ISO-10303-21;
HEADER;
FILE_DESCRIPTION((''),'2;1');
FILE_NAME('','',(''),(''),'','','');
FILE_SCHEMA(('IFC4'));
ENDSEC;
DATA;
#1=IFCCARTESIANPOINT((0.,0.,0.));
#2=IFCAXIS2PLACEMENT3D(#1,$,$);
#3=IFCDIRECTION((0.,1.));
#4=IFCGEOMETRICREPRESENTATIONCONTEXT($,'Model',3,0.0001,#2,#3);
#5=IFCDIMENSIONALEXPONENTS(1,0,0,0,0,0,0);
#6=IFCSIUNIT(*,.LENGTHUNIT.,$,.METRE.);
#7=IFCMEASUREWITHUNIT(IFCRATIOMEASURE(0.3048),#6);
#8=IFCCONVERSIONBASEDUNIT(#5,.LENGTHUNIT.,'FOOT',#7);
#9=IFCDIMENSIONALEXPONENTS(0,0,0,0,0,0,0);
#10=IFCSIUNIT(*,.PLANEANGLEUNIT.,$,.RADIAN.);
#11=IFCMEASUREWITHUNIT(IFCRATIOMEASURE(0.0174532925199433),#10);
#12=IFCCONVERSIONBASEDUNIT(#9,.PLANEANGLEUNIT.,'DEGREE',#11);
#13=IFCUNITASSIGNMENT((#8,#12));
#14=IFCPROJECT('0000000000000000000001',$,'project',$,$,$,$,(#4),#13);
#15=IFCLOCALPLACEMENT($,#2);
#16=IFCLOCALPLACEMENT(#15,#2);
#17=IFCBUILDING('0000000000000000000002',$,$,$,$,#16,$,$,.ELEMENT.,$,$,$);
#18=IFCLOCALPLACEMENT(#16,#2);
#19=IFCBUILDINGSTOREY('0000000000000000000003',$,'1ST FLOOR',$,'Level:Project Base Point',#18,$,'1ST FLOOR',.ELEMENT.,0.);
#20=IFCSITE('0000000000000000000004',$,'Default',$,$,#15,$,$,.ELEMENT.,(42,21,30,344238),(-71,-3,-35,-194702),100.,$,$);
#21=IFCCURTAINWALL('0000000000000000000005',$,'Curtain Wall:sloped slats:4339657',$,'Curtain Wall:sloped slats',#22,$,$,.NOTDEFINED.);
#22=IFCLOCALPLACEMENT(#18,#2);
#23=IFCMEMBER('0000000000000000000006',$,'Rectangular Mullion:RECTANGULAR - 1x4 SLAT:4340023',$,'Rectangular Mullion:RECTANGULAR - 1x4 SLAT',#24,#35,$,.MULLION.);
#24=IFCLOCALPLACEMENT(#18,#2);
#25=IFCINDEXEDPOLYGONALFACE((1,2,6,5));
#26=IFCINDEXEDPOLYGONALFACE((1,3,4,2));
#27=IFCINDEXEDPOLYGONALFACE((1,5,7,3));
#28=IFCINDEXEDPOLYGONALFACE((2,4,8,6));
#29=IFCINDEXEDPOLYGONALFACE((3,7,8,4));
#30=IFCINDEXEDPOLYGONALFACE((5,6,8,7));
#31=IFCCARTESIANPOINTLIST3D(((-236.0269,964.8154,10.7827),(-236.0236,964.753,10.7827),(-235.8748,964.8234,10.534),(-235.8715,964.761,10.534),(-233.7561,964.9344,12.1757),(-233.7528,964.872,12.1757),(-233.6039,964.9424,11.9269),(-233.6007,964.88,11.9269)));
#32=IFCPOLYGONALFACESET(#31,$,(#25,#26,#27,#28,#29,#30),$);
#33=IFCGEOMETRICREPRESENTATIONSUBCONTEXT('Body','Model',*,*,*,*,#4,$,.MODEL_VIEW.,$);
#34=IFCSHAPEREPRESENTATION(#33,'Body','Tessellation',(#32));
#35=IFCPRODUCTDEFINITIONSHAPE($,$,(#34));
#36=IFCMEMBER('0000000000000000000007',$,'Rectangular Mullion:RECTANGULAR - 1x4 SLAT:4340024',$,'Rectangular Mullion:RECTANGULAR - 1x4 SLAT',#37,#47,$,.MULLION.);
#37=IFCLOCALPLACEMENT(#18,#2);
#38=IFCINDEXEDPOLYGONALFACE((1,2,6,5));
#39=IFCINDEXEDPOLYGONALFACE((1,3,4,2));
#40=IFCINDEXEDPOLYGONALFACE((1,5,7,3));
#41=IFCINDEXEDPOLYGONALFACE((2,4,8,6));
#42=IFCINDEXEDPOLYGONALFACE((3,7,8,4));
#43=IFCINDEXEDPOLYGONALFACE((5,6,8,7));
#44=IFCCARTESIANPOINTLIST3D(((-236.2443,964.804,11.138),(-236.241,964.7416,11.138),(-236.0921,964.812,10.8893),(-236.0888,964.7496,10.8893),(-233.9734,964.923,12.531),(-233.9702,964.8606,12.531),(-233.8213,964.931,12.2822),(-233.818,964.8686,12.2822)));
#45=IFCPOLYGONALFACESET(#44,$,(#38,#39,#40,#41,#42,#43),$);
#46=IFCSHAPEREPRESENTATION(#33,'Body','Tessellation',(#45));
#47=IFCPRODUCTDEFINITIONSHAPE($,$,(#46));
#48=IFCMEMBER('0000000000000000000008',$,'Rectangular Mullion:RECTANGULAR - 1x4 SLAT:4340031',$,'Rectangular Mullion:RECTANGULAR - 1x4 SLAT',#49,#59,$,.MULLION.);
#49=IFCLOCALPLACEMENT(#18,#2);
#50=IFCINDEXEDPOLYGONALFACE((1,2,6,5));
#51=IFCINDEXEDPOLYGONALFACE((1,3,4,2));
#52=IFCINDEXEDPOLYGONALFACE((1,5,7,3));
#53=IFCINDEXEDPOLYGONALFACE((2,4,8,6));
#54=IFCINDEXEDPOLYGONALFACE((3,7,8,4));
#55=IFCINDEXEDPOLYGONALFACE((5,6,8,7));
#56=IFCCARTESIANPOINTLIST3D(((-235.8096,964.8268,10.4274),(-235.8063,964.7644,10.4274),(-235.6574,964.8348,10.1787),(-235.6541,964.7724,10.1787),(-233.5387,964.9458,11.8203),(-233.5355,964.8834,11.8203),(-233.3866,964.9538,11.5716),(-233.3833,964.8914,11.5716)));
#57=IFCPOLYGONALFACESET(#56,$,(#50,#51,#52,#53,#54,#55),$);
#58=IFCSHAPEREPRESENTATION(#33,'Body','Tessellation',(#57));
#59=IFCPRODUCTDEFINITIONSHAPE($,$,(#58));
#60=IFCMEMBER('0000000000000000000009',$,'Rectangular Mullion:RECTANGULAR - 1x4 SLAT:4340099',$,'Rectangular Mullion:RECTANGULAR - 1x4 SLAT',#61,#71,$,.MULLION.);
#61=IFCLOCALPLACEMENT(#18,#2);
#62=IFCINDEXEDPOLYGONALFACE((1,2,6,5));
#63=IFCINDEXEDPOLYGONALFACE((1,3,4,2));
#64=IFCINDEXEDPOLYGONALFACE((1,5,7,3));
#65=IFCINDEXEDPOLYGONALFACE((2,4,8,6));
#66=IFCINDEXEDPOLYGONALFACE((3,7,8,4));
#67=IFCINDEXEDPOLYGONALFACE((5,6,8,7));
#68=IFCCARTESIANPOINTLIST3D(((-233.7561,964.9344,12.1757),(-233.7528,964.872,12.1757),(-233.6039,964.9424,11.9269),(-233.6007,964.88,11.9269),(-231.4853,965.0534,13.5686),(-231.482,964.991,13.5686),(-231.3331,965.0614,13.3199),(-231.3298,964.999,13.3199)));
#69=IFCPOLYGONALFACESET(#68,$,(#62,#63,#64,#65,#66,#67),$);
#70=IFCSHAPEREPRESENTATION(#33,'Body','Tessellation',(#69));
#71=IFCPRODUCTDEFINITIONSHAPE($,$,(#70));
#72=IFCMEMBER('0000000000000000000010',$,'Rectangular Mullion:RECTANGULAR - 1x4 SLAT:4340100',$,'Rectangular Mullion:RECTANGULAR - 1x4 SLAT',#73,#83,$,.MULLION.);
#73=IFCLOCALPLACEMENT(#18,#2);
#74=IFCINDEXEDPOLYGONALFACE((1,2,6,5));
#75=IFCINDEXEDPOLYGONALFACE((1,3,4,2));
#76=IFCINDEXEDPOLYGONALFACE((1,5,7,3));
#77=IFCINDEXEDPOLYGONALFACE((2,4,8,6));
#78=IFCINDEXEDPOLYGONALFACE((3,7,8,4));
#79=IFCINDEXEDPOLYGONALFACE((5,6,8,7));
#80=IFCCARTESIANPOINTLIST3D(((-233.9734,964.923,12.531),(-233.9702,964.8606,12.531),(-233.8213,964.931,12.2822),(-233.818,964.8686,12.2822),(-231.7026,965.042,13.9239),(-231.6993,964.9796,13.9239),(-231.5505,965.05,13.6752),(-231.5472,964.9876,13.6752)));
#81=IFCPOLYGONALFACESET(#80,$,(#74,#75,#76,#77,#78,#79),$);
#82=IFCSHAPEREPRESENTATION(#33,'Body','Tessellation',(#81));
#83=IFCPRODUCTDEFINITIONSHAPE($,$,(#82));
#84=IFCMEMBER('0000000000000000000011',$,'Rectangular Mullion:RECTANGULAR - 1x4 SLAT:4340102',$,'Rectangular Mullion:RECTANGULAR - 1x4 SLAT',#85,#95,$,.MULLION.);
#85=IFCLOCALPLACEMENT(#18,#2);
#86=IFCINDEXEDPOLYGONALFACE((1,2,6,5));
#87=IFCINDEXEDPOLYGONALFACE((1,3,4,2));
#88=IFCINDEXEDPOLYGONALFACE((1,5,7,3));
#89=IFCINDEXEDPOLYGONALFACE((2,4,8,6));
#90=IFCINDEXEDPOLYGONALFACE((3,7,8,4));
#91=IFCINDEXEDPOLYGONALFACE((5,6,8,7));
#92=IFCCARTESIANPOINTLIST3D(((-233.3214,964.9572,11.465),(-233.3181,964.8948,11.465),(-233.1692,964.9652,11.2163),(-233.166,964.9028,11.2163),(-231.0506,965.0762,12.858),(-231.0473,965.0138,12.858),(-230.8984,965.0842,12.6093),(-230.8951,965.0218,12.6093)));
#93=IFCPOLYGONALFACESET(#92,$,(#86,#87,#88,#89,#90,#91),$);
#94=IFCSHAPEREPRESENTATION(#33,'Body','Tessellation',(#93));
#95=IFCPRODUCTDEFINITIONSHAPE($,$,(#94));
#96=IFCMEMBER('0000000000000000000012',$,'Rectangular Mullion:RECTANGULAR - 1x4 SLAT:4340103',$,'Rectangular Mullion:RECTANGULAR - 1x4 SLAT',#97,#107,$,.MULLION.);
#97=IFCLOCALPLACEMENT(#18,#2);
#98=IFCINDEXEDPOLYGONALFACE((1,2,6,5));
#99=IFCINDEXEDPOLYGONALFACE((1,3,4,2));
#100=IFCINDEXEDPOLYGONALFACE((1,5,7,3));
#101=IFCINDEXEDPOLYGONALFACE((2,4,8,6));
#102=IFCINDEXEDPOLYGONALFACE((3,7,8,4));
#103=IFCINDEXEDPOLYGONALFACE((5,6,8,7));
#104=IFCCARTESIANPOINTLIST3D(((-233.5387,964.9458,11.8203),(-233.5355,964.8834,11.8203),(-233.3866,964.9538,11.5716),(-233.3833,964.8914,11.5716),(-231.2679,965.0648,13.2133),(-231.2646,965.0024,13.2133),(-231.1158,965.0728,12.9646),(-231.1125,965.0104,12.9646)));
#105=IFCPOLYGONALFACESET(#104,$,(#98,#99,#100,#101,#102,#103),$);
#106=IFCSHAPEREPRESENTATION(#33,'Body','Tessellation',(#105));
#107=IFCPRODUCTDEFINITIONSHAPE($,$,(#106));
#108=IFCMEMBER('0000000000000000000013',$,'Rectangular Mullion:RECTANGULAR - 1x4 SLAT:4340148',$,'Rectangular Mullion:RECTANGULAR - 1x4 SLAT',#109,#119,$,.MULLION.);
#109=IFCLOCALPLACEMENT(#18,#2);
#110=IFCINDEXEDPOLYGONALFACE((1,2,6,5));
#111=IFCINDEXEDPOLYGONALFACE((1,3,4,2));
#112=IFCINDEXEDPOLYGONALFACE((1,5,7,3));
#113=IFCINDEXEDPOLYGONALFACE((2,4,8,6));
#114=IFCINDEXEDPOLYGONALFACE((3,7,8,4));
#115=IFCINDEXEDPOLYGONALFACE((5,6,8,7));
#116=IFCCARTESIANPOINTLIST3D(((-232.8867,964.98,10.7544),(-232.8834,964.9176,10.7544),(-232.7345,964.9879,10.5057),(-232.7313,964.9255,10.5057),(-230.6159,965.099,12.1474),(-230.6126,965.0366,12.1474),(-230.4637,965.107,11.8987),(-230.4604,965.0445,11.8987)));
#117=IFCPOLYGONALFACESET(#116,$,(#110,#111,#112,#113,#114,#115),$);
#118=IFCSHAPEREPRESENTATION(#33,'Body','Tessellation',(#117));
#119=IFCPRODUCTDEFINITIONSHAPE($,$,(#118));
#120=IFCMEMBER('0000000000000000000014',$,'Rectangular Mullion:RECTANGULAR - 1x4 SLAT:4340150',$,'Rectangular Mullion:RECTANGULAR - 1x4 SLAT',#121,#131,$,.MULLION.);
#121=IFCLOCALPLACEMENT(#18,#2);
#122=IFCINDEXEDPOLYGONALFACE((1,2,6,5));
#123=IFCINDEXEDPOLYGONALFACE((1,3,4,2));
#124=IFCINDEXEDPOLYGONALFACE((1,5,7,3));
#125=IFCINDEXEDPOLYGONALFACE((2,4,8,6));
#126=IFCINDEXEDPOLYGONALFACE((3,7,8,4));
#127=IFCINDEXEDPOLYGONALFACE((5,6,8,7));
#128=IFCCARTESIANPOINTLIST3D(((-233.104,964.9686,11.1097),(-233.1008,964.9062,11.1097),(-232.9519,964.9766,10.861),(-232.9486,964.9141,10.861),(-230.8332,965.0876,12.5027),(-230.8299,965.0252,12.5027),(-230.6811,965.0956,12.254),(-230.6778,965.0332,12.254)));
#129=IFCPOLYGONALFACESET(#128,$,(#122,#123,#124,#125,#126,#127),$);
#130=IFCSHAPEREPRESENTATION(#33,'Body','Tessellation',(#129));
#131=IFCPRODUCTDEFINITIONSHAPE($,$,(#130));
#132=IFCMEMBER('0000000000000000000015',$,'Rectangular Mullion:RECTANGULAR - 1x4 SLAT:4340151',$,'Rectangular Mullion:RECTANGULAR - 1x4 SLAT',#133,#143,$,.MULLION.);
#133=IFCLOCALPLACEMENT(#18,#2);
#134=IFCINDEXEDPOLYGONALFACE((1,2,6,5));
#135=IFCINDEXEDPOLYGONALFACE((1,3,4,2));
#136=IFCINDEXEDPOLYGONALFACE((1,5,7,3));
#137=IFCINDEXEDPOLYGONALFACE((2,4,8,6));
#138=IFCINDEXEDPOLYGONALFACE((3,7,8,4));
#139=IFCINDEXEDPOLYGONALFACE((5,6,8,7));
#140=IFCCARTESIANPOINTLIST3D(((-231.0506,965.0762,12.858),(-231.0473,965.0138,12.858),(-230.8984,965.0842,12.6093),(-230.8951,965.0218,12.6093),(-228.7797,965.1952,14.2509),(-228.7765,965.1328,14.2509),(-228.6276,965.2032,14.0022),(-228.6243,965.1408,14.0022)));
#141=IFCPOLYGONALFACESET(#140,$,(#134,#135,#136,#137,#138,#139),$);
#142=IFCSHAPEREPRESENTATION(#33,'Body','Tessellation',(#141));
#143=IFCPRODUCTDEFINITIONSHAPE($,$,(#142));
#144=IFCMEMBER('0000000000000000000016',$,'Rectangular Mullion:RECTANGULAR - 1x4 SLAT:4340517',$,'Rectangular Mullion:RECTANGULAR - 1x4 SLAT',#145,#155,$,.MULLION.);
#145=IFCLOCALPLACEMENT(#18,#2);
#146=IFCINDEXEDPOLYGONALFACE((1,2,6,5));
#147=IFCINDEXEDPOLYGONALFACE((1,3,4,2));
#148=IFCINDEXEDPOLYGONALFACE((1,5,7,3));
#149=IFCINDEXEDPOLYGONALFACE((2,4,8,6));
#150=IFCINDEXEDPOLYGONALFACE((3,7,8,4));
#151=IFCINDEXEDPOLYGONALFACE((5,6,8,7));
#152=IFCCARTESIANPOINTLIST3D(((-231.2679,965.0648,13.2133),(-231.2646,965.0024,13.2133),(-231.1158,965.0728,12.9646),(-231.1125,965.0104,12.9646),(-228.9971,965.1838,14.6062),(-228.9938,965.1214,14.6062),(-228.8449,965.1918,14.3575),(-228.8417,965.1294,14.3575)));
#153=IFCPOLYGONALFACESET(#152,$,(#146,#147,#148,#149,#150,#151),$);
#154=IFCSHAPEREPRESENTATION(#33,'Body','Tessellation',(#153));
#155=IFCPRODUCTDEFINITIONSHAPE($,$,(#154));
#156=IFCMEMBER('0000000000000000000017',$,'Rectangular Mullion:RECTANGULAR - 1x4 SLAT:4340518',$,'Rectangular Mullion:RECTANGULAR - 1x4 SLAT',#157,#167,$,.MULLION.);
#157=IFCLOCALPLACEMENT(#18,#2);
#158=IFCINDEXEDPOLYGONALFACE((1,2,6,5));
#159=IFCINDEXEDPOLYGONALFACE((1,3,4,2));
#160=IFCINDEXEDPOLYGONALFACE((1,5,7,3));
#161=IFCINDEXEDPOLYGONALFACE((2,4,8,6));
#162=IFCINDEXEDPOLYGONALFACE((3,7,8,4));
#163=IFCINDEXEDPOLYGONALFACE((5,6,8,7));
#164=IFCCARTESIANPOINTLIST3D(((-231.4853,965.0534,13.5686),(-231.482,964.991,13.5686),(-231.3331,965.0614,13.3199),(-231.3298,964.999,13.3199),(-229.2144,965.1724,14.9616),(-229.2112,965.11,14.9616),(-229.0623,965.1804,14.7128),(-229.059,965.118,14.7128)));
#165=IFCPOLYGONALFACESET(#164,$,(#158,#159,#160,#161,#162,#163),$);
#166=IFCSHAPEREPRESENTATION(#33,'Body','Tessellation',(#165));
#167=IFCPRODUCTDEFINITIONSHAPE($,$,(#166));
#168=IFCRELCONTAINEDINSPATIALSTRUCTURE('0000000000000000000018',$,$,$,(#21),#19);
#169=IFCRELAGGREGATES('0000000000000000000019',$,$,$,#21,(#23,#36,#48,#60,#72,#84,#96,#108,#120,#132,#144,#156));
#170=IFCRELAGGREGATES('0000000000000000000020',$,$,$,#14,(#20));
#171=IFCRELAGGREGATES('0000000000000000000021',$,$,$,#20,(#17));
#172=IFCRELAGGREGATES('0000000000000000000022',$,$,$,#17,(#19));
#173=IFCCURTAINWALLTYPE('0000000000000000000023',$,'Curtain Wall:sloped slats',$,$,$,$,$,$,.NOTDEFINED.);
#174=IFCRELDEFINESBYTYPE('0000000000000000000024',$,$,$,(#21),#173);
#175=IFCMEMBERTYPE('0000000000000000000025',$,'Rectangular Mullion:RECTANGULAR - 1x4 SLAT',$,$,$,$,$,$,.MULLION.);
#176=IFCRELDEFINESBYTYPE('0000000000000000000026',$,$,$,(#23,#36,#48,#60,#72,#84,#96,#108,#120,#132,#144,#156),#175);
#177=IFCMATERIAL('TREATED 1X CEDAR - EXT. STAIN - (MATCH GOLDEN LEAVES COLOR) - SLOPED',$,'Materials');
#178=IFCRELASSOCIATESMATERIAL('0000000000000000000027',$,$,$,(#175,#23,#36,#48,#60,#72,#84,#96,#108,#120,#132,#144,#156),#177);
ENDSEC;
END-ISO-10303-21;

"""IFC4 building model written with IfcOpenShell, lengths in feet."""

from ifc_helpers import new_model, entity, si_unit, converted_unit, direction, frame, frame_2d, origin, place, context, subcontext, project, spatial, rectangle, extrude, source, transform, mapped, material, material_profile, profile_set, profile_usage, type_object, type_shapes, element, aggregate, save


model = new_model("IFC4")

# Units and contexts
model_context = context("Model", 3, precision=0.0001, world=origin(), true_north=direction((0.0, 1.0)))
body_context = subcontext(model_context, "Body", "Model", "MODEL_VIEW")
ifc_project = project(units=[converted_unit("LENGTHUNIT", "FOOT", entity("IfcRatioMeasure", 0.3048), si_unit("LENGTHUNIT", "METRE"), dimensions=[1, 0, 0, 0, 0, 0, 0]), converted_unit("PLANEANGLEUNIT", "DEGREE", entity("IfcRatioMeasure", 0.0174532925199433), si_unit("PLANEANGLEUNIT", "RADIAN"), dimensions=[0, 0, 0, 0, 0, 0, 0])], contexts=[model_context])

# Site, building, storey
site_placement = place(None, origin())
site = spatial("IfcSite", under=ifc_project, at=site_placement, Name="Default", CompositionType="ELEMENT", RefLatitude=(42, 21, 30, 344238), RefLongitude=(-71, -3, -35, -194702), RefElevation=100.0)
building_placement = place(site_placement, origin())
building = spatial("IfcBuilding", under=site, at=building_placement, CompositionType="ELEMENT")
storey_placement = place(building_placement, origin())
storey = spatial("IfcBuildingStorey", under=building, at=storey_placement, Name="1ST FLOOR", ObjectType="Level:Project Base Point", LongName="1ST FLOOR", CompositionType="ELEMENT", Elevation=0.0)

# Curtain wall, members
curtain_wall_type_1 = type_object("IfcCurtainWallType", Name="Curtain Wall:sloped slats", PredefinedType="NOTDEFINED")
curtain_wall_1_placement = place(storey_placement, origin())
curtain_wall_1 = element("IfcCurtainWall", 1, at=curtain_wall_1_placement, inside=storey, type_object=curtain_wall_type_1, Name="Curtain Wall:sloped slats:4339657", ObjectType="Curtain Wall:sloped slats", PredefinedType="NOTDEFINED")
ifc_material_1 = material(Name="TREATED 1X CEDAR - EXT. STAIN - (MATCH GOLDEN LEAVES COLOR) - SLOPED", Category="Materials")
ifc_material_profile_1 = material_profile(ifc_material_1, rectangle(XDim=0.0625, YDim=0.2917, at=frame_2d((0.0, 0.0), x_axis=(1.0, 0.0))), Name="RECTANGULAR - 1x4 SLAT")
ifc_profile_set_1 = profile_set([ifc_material_profile_1], Name="RECTANGULAR - 1x4 SLAT")
ifc_profile_usage_1 = profile_usage(ifc_profile_set_1)
member_type_1 = type_object("IfcMemberType", Name="Rectangular Mullion:RECTANGULAR - 1x4 SLAT", PredefinedType="MULLION", material=ifc_profile_set_1)
shared_shape_1 = source(origin(), body_context, "Body", "SweptSolid", [
    extrude(rectangle(XDim=0.0625, YDim=0.2917, at=frame_2d((0.0, 0.0), x_axis=(1.0, 0.0))), frame((0.0, 0.0, -2.6667), z_axis=(0.0, 0.0, 1.0), x_axis=(0.0, -1.0, 0.0)), (0.0, 0.0, 1.0), 2.6667),
])
type_shapes(member_type_1, [shared_shape_1])
member_1_placement = place(storey_placement, frame((-235.9492, 964.7882, 10.6583), z_axis=(-0.851559, -0.044628, -0.522356), x_axis=(-0.52164, -0.027338, 0.852727)))
member_1 = element("IfcMember", 2, at=member_1_placement, type_object=member_type_1, material=ifc_profile_usage_1, Name="Rectangular Mullion:RECTANGULAR - 1x4 SLAT:4340023", ObjectType="Rectangular Mullion:RECTANGULAR - 1x4 SLAT", PredefinedType="MULLION", context=body_context, shape_type="MappedRepresentation", body=[
    mapped(shared_shape_1, transform((0.0, 0.0, 0.0), scale=1.0)),
])
ifc_profile_usage_2 = profile_usage(ifc_profile_set_1)
member_2_placement = place(storey_placement, frame((-236.1666, 964.7768, 11.0136), z_axis=(-0.851559, -0.044628, -0.522356), x_axis=(-0.52164, -0.027338, 0.852727)))
member_2 = element("IfcMember", 3, at=member_2_placement, type_object=member_type_1, material=ifc_profile_usage_2, Name="Rectangular Mullion:RECTANGULAR - 1x4 SLAT:4340024", ObjectType="Rectangular Mullion:RECTANGULAR - 1x4 SLAT", PredefinedType="MULLION", context=body_context, shape_type="MappedRepresentation", body=[
    mapped(shared_shape_1, transform((0.0, 0.0, 0.0), scale=1.0)),
])
ifc_profile_usage_3 = profile_usage(ifc_profile_set_1)
member_3_placement = place(storey_placement, frame((-235.7319, 964.7996, 10.303), z_axis=(-0.851559, -0.044628, -0.522356), x_axis=(-0.52164, -0.027338, 0.852727)))
member_3 = element("IfcMember", 4, at=member_3_placement, type_object=member_type_1, material=ifc_profile_usage_3, Name="Rectangular Mullion:RECTANGULAR - 1x4 SLAT:4340031", ObjectType="Rectangular Mullion:RECTANGULAR - 1x4 SLAT", PredefinedType="MULLION", context=body_context, shape_type="MappedRepresentation", body=[
    mapped(shared_shape_1, transform((0.0, 0.0, 0.0), scale=1.0)),
])
ifc_profile_usage_4 = profile_usage(ifc_profile_set_1)
member_4_placement = place(storey_placement, frame((-233.6784, 964.9072, 12.0513), z_axis=(-0.851559, -0.044628, -0.522356), x_axis=(-0.52164, -0.027338, 0.852727)))
member_4 = element("IfcMember", 5, at=member_4_placement, type_object=member_type_1, material=ifc_profile_usage_4, Name="Rectangular Mullion:RECTANGULAR - 1x4 SLAT:4340099", ObjectType="Rectangular Mullion:RECTANGULAR - 1x4 SLAT", PredefinedType="MULLION", context=body_context, shape_type="MappedRepresentation", body=[
    mapped(shared_shape_1, transform((0.0, 0.0, 0.0), scale=1.0)),
])
ifc_profile_usage_5 = profile_usage(ifc_profile_set_1)
member_5_placement = place(storey_placement, frame((-233.8957, 964.8958, 12.4066), z_axis=(-0.851559, -0.044628, -0.522356), x_axis=(-0.52164, -0.027338, 0.852727)))
member_5 = element("IfcMember", 6, at=member_5_placement, type_object=member_type_1, material=ifc_profile_usage_5, Name="Rectangular Mullion:RECTANGULAR - 1x4 SLAT:4340100", ObjectType="Rectangular Mullion:RECTANGULAR - 1x4 SLAT", PredefinedType="MULLION", context=body_context, shape_type="MappedRepresentation", body=[
    mapped(shared_shape_1, transform((0.0, 0.0, 0.0), scale=1.0)),
])
ifc_profile_usage_6 = profile_usage(ifc_profile_set_1)
member_6_placement = place(storey_placement, frame((-233.2437, 964.93, 11.3407), z_axis=(-0.851559, -0.044628, -0.522356), x_axis=(-0.52164, -0.027338, 0.852727)))
member_6 = element("IfcMember", 7, at=member_6_placement, type_object=member_type_1, material=ifc_profile_usage_6, Name="Rectangular Mullion:RECTANGULAR - 1x4 SLAT:4340102", ObjectType="Rectangular Mullion:RECTANGULAR - 1x4 SLAT", PredefinedType="MULLION", context=body_context, shape_type="MappedRepresentation", body=[
    mapped(shared_shape_1, transform((0.0, 0.0, 0.0), scale=1.0)),
])
ifc_profile_usage_7 = profile_usage(ifc_profile_set_1)
member_7_placement = place(storey_placement, frame((-233.461, 964.9186, 11.696), z_axis=(-0.851559, -0.044628, -0.522356), x_axis=(-0.52164, -0.027338, 0.852727)))
member_7 = element("IfcMember", 8, at=member_7_placement, type_object=member_type_1, material=ifc_profile_usage_7, Name="Rectangular Mullion:RECTANGULAR - 1x4 SLAT:4340103", ObjectType="Rectangular Mullion:RECTANGULAR - 1x4 SLAT", PredefinedType="MULLION", context=body_context, shape_type="MappedRepresentation", body=[
    mapped(shared_shape_1, transform((0.0, 0.0, 0.0), scale=1.0)),
])
ifc_profile_usage_8 = profile_usage(ifc_profile_set_1)
member_8_placement = place(storey_placement, frame((-232.809, 964.9528, 10.6301), z_axis=(-0.851559, -0.044628, -0.522356), x_axis=(-0.52164, -0.027338, 0.852727)))
member_8 = element("IfcMember", 9, at=member_8_placement, type_object=member_type_1, material=ifc_profile_usage_8, Name="Rectangular Mullion:RECTANGULAR - 1x4 SLAT:4340148", ObjectType="Rectangular Mullion:RECTANGULAR - 1x4 SLAT", PredefinedType="MULLION", context=body_context, shape_type="MappedRepresentation", body=[
    mapped(shared_shape_1, transform((0.0, 0.0, 0.0), scale=1.0)),
])
ifc_profile_usage_9 = profile_usage(ifc_profile_set_1)
member_9_placement = place(storey_placement, frame((-233.0263, 964.9414, 10.9854), z_axis=(-0.851559, -0.044628, -0.522356), x_axis=(-0.52164, -0.027338, 0.852727)))
member_9 = element("IfcMember", 10, at=member_9_placement, type_object=member_type_1, material=ifc_profile_usage_9, Name="Rectangular Mullion:RECTANGULAR - 1x4 SLAT:4340150", ObjectType="Rectangular Mullion:RECTANGULAR - 1x4 SLAT", PredefinedType="MULLION", context=body_context, shape_type="MappedRepresentation", body=[
    mapped(shared_shape_1, transform((0.0, 0.0, 0.0), scale=1.0)),
])
ifc_profile_usage_10 = profile_usage(ifc_profile_set_1)
member_10_placement = place(storey_placement, frame((-230.9729, 965.049, 12.7336), z_axis=(-0.851559, -0.044628, -0.522356), x_axis=(-0.52164, -0.027338, 0.852727)))
member_10 = element("IfcMember", 11, at=member_10_placement, type_object=member_type_1, material=ifc_profile_usage_10, Name="Rectangular Mullion:RECTANGULAR - 1x4 SLAT:4340151", ObjectType="Rectangular Mullion:RECTANGULAR - 1x4 SLAT", PredefinedType="MULLION", context=body_context, shape_type="MappedRepresentation", body=[
    mapped(shared_shape_1, transform((0.0, 0.0, 0.0), scale=1.0)),
])
ifc_profile_usage_11 = profile_usage(ifc_profile_set_1)
member_11_placement = place(storey_placement, frame((-231.1902, 965.0376, 13.0889), z_axis=(-0.851559, -0.044628, -0.522356), x_axis=(-0.52164, -0.027338, 0.852727)))
member_11 = element("IfcMember", 12, at=member_11_placement, type_object=member_type_1, material=ifc_profile_usage_11, Name="Rectangular Mullion:RECTANGULAR - 1x4 SLAT:4340517", ObjectType="Rectangular Mullion:RECTANGULAR - 1x4 SLAT", PredefinedType="MULLION", context=body_context, shape_type="MappedRepresentation", body=[
    mapped(shared_shape_1, transform((0.0, 0.0, 0.0), scale=1.0)),
])
ifc_profile_usage_12 = profile_usage(ifc_profile_set_1)
member_12_placement = place(storey_placement, frame((-231.4076, 965.0262, 13.4442), z_axis=(-0.851559, -0.044628, -0.522356), x_axis=(-0.52164, -0.027338, 0.852727)))
member_12 = element("IfcMember", 13, at=member_12_placement, type_object=member_type_1, material=ifc_profile_usage_12, Name="Rectangular Mullion:RECTANGULAR - 1x4 SLAT:4340518", ObjectType="Rectangular Mullion:RECTANGULAR - 1x4 SLAT", PredefinedType="MULLION", context=body_context, shape_type="MappedRepresentation", body=[
    mapped(shared_shape_1, transform((0.0, 0.0, 0.0), scale=1.0)),
])
aggregate(curtain_wall_1, [member_1, member_2, member_3, member_4, member_5, member_6, member_7, member_8, member_9, member_10, member_11, member_12])

save(model, "model.ifc")
